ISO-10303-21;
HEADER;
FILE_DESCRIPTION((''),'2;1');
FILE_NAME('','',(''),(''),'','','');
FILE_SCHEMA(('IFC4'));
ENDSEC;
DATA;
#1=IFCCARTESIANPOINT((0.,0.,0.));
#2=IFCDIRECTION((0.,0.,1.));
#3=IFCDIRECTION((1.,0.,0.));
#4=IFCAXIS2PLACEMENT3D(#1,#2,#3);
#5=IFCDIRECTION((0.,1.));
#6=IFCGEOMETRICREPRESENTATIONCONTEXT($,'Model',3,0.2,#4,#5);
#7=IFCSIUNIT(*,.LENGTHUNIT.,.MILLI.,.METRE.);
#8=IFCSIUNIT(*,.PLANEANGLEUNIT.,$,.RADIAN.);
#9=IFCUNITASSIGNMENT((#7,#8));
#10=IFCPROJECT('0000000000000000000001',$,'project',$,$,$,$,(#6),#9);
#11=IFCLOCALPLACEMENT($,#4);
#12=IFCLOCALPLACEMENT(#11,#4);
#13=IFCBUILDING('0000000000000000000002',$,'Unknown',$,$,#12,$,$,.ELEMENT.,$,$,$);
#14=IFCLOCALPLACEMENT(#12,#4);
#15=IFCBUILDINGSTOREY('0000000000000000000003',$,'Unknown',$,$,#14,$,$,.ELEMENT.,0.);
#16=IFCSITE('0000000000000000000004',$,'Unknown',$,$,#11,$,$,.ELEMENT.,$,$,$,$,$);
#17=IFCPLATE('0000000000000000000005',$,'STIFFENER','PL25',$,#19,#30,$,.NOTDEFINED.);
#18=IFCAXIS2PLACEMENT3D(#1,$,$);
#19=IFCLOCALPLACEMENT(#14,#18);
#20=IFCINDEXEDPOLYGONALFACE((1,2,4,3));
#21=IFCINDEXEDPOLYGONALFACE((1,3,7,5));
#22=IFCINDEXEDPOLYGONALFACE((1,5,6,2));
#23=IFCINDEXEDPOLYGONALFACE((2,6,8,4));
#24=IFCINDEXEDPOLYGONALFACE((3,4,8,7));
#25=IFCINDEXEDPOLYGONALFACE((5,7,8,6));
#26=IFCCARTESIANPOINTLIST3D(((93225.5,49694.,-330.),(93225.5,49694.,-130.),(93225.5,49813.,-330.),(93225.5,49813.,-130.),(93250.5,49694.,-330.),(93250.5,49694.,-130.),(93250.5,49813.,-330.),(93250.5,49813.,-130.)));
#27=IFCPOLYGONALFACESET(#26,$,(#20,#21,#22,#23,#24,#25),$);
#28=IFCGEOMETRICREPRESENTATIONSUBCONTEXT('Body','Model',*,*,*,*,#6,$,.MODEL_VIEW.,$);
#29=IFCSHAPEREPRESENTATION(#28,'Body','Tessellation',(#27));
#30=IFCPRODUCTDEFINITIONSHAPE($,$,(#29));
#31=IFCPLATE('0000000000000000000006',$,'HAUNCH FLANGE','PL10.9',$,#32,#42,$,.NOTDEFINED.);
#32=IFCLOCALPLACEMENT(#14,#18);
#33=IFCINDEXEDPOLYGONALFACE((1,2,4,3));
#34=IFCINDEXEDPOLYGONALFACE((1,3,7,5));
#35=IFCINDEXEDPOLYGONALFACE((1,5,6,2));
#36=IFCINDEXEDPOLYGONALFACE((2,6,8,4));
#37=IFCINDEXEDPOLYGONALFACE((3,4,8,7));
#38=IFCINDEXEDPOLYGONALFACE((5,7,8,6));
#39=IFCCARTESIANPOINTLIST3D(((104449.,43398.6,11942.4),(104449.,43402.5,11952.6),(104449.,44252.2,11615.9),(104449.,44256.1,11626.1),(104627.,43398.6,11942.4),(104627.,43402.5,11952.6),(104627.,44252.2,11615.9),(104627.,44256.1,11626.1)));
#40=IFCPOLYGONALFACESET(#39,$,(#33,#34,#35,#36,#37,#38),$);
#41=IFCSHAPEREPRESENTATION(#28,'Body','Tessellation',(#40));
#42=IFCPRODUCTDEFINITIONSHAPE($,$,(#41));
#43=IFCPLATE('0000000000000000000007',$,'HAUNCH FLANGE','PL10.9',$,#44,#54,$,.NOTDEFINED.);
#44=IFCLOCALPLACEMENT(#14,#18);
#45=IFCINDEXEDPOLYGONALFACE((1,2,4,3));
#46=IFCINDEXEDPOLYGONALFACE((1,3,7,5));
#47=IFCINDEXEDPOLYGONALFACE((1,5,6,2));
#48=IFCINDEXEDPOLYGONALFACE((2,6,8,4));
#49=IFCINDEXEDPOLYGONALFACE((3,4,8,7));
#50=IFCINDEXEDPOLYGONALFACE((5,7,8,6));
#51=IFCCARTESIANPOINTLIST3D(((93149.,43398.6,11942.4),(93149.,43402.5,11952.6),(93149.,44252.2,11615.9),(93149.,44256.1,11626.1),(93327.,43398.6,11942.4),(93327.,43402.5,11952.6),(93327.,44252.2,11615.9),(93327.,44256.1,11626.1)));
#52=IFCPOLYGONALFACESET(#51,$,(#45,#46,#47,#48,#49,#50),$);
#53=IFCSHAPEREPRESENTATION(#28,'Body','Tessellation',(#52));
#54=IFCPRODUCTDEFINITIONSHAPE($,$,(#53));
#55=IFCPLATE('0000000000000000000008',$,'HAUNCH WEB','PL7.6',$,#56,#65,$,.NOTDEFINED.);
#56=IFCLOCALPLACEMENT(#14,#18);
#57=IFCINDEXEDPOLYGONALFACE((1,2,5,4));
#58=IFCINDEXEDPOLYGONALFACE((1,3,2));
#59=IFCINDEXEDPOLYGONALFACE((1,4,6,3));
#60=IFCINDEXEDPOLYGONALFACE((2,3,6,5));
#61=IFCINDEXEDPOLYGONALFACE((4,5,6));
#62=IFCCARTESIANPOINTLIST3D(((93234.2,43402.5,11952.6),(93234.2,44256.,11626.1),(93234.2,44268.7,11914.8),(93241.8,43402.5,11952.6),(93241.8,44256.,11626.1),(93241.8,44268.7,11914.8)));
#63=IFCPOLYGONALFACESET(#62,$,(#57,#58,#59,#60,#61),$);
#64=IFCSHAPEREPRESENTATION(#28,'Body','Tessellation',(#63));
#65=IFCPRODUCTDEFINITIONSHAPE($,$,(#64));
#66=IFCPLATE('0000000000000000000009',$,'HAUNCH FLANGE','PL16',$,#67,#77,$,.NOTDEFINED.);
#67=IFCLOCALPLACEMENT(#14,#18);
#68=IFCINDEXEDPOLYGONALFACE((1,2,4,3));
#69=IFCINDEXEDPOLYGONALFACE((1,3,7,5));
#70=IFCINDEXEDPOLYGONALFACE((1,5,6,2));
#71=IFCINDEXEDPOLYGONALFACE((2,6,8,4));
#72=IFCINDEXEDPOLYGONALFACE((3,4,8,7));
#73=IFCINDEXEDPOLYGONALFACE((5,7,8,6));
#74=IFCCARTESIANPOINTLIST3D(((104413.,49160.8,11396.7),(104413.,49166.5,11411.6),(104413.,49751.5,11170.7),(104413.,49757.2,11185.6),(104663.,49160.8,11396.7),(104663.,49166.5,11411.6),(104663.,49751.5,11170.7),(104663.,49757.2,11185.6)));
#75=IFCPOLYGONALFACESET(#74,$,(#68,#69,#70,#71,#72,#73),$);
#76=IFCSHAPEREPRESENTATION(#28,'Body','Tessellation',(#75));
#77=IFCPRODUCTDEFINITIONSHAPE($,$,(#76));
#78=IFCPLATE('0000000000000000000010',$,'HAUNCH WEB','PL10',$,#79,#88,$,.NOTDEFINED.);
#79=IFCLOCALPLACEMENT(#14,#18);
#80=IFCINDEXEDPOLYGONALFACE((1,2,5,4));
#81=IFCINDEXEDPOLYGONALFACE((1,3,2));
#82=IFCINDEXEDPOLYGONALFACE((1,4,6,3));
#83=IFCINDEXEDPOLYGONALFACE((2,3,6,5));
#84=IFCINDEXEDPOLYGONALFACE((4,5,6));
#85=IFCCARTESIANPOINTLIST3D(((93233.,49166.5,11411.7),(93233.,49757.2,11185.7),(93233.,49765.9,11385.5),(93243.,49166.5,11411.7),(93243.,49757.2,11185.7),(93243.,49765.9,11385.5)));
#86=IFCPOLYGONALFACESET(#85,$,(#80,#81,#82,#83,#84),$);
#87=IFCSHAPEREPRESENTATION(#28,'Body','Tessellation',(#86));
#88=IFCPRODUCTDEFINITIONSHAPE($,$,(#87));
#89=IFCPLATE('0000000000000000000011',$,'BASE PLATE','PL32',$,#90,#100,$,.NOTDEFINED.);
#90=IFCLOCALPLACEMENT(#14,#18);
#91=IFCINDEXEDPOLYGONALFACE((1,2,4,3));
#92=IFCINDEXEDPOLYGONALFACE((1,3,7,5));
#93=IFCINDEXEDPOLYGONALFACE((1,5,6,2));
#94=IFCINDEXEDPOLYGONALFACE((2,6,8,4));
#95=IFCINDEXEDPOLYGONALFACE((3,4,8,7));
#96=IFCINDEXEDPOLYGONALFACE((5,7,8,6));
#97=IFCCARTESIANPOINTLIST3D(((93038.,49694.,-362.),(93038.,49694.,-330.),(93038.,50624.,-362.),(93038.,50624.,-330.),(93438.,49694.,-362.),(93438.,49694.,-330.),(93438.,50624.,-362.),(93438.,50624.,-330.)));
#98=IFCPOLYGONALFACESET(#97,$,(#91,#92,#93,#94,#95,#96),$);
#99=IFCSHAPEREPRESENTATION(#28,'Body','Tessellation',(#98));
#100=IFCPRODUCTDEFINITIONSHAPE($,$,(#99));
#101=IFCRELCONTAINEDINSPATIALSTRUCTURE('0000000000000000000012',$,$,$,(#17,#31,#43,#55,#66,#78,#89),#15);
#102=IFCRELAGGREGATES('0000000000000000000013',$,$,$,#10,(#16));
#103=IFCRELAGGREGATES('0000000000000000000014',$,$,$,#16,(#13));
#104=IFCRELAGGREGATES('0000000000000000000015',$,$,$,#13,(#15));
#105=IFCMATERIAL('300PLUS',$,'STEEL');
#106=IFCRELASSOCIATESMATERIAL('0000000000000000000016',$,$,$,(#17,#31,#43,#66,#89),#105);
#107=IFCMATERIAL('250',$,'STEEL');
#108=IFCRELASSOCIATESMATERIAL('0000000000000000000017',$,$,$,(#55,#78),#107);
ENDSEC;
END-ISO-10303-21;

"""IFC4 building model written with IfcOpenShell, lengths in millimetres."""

from ifc_helpers import new_model, si_unit, direction, frame, origin_with_axes, place, context, subcontext, project, spatial, line, indexed_curve, outline, extrude, material, element, save


model = new_model("IFC4")

# Units and contexts
model_context = context("Model", 3, precision=0.2, world=origin_with_axes(), true_north=direction((0.0, 1.0)))
body_context = subcontext(model_context, "Body", "Model", "MODEL_VIEW")
ifc_project = project(units=[si_unit("LENGTHUNIT", "METRE", prefix="MILLI"), si_unit("PLANEANGLEUNIT", "RADIAN")], contexts=[model_context])

# Site, building, storey
site_placement = place(None, origin_with_axes())
site = spatial("IfcSite", under=ifc_project, at=site_placement, Name="Unknown", CompositionType="ELEMENT")
building_placement = place(site_placement, origin_with_axes())
building = spatial("IfcBuilding", under=site, at=building_placement, Name="Unknown", CompositionType="ELEMENT")
storey_placement = place(building_placement, origin_with_axes())
storey = spatial("IfcBuildingStorey", under=building, at=storey_placement, Name="Unknown", CompositionType="ELEMENT", Elevation=0.0)

# Shared definitions
ifc_material_1 = material(Name="300PLUS", Category="STEEL")

# Plates
plate_1_placement = place(storey_placement, frame((93238.0, 49813.0, -130.0), z_axis=(1.0, 0.0, 0.0), x_axis=(0.0, -1.0, 0.0)))
element("IfcPlate", 1, at=plate_1_placement, inside=storey, material=ifc_material_1, Name="STIFFENER", Description="PL25", PredefinedType="NOTDEFINED", context=body_context, shape_type="SolidModel", body=[
    extrude(outline(indexed_curve([(0.0, 0.0), (119.0, 0.0), (119.0, 200.0), (0.0, 200.0)], segments=[line(1, 2, 3, 4, 1)])), frame((0.0, 0.0, 12.5), z_axis=(0.0, 0.0, 1.0), x_axis=(1.0, 0.0, 0.0)), (0.0, 0.0, -1.0), 25.0),
])
for number, where, z_axis, x_axis, name in (
    (2, (104449.0, 44254.1, 11621.0), (0.0, 0.357255, 0.934007), (0.0, -0.934007, 0.357255), "HAUNCH FLANGE"),
    (3, (93149.0, 44254.1, 11621.0), (0.0, 0.357255, 0.934007), (0.0, -0.934007, 0.357255), "HAUNCH FLANGE"),
):
    element("IfcPlate", number, at=place(storey_placement, frame(where, z_axis=z_axis, x_axis=x_axis)), inside=storey, material=ifc_material_1, Name=name, Description="PL10.9", PredefinedType="NOTDEFINED", context=body_context, shape_type="SolidModel", body=[
        extrude(outline(indexed_curve([(0.0, 0.0), (913.9, 0.0), (913.9, 178.0), (0.0, 178.0)], segments=[line(1, 2, 3, 4, 1)])), frame((0.0, 0.0, 5.5), z_axis=(0.0, 0.0, 1.0), x_axis=(1.0, 0.0, 0.0)), (0.0, 0.0, -1.0), 10.9),
    ])
ifc_material_2 = material(Name="250", Category="STEEL")
plate_2_placement = place(storey_placement, frame((93238.0, 44268.7, 11914.8), z_axis=(-1.0, 0.0, 0.0), x_axis=(0.0, -0.043948, -0.999034)))
element("IfcPlate", 4, at=plate_2_placement, inside=storey, material=ifc_material_2, Name="HAUNCH WEB", Description="PL7.6", PredefinedType="NOTDEFINED", context=body_context, shape_type="SolidModel", body=[
    extrude(outline(indexed_curve([(0.0, 0.0), (289.0, 0.0), (0.3, 867.0)], segments=[line(1, 2, 3, 1)])), frame((0.0, 0.0, 3.8), z_axis=(0.0, 0.0, 1.0), x_axis=(1.0, 0.0, 0.0)), (0.0, 0.0, -1.0), 7.6),
])
plate_3_placement = place(storey_placement, frame((104413.0, 49754.4, 11178.2), z_axis=(0.0, 0.357336, 0.933976), x_axis=(0.0, -0.933976, 0.357336)))
element("IfcPlate", 5, at=plate_3_placement, inside=storey, material=ifc_material_1, Name="HAUNCH FLANGE", Description="PL16", PredefinedType="NOTDEFINED", context=body_context, shape_type="SolidModel", body=[
    extrude(outline(indexed_curve([(0.0, 0.0), (632.5, 0.0), (632.5, 250.0), (0.0, 250.0)], segments=[line(1, 2, 3, 4, 1)])), frame((0.0, 0.0, 8.0), z_axis=(0.0, 0.0, 1.0), x_axis=(1.0, 0.0, 0.0)), (0.0, 0.0, -1.0), 16.0),
])
plate_4_placement = place(storey_placement, frame((93238.0, 49765.9, 11385.5), z_axis=(-1.0, 0.0, 0.0), x_axis=(0.0, -0.043502, -0.999053)))
element("IfcPlate", 6, at=plate_4_placement, inside=storey, material=ifc_material_2, Name="HAUNCH WEB", Description="PL10", PredefinedType="NOTDEFINED", context=body_context, shape_type="SolidModel", body=[
    extrude(outline(indexed_curve([(0.0, 0.0), (200.0, 0.0), (-0.1, 600.0)], segments=[line(1, 2, 3, 1)])), frame((0.0, 0.0, 5.0), z_axis=(0.0, 0.0, 1.0), x_axis=(1.0, 0.0, 0.0)), (0.0, 0.0, -1.0), 10.0),
])
plate_5_placement = place(storey_placement, frame((93438.0, 49694.0, -346.0), z_axis=(0.0, 0.0, 1.0), x_axis=(0.0, 1.0, 0.0)))
element("IfcPlate", 7, at=plate_5_placement, inside=storey, material=ifc_material_1, Name="BASE PLATE", Description="PL32", PredefinedType="NOTDEFINED", context=body_context, shape_type="SolidModel", body=[
    extrude(outline(indexed_curve([(0.0, 0.0), (930.0, 0.0), (930.0, 400.0), (0.0, 400.0)], segments=[line(1, 2, 3, 4, 1)])), frame((0.0, 0.0, 16.0), z_axis=(0.0, 0.0, 1.0), x_axis=(1.0, 0.0, 0.0)), (0.0, 0.0, -1.0), 32.0),
])

save(model, "model.ifc")
